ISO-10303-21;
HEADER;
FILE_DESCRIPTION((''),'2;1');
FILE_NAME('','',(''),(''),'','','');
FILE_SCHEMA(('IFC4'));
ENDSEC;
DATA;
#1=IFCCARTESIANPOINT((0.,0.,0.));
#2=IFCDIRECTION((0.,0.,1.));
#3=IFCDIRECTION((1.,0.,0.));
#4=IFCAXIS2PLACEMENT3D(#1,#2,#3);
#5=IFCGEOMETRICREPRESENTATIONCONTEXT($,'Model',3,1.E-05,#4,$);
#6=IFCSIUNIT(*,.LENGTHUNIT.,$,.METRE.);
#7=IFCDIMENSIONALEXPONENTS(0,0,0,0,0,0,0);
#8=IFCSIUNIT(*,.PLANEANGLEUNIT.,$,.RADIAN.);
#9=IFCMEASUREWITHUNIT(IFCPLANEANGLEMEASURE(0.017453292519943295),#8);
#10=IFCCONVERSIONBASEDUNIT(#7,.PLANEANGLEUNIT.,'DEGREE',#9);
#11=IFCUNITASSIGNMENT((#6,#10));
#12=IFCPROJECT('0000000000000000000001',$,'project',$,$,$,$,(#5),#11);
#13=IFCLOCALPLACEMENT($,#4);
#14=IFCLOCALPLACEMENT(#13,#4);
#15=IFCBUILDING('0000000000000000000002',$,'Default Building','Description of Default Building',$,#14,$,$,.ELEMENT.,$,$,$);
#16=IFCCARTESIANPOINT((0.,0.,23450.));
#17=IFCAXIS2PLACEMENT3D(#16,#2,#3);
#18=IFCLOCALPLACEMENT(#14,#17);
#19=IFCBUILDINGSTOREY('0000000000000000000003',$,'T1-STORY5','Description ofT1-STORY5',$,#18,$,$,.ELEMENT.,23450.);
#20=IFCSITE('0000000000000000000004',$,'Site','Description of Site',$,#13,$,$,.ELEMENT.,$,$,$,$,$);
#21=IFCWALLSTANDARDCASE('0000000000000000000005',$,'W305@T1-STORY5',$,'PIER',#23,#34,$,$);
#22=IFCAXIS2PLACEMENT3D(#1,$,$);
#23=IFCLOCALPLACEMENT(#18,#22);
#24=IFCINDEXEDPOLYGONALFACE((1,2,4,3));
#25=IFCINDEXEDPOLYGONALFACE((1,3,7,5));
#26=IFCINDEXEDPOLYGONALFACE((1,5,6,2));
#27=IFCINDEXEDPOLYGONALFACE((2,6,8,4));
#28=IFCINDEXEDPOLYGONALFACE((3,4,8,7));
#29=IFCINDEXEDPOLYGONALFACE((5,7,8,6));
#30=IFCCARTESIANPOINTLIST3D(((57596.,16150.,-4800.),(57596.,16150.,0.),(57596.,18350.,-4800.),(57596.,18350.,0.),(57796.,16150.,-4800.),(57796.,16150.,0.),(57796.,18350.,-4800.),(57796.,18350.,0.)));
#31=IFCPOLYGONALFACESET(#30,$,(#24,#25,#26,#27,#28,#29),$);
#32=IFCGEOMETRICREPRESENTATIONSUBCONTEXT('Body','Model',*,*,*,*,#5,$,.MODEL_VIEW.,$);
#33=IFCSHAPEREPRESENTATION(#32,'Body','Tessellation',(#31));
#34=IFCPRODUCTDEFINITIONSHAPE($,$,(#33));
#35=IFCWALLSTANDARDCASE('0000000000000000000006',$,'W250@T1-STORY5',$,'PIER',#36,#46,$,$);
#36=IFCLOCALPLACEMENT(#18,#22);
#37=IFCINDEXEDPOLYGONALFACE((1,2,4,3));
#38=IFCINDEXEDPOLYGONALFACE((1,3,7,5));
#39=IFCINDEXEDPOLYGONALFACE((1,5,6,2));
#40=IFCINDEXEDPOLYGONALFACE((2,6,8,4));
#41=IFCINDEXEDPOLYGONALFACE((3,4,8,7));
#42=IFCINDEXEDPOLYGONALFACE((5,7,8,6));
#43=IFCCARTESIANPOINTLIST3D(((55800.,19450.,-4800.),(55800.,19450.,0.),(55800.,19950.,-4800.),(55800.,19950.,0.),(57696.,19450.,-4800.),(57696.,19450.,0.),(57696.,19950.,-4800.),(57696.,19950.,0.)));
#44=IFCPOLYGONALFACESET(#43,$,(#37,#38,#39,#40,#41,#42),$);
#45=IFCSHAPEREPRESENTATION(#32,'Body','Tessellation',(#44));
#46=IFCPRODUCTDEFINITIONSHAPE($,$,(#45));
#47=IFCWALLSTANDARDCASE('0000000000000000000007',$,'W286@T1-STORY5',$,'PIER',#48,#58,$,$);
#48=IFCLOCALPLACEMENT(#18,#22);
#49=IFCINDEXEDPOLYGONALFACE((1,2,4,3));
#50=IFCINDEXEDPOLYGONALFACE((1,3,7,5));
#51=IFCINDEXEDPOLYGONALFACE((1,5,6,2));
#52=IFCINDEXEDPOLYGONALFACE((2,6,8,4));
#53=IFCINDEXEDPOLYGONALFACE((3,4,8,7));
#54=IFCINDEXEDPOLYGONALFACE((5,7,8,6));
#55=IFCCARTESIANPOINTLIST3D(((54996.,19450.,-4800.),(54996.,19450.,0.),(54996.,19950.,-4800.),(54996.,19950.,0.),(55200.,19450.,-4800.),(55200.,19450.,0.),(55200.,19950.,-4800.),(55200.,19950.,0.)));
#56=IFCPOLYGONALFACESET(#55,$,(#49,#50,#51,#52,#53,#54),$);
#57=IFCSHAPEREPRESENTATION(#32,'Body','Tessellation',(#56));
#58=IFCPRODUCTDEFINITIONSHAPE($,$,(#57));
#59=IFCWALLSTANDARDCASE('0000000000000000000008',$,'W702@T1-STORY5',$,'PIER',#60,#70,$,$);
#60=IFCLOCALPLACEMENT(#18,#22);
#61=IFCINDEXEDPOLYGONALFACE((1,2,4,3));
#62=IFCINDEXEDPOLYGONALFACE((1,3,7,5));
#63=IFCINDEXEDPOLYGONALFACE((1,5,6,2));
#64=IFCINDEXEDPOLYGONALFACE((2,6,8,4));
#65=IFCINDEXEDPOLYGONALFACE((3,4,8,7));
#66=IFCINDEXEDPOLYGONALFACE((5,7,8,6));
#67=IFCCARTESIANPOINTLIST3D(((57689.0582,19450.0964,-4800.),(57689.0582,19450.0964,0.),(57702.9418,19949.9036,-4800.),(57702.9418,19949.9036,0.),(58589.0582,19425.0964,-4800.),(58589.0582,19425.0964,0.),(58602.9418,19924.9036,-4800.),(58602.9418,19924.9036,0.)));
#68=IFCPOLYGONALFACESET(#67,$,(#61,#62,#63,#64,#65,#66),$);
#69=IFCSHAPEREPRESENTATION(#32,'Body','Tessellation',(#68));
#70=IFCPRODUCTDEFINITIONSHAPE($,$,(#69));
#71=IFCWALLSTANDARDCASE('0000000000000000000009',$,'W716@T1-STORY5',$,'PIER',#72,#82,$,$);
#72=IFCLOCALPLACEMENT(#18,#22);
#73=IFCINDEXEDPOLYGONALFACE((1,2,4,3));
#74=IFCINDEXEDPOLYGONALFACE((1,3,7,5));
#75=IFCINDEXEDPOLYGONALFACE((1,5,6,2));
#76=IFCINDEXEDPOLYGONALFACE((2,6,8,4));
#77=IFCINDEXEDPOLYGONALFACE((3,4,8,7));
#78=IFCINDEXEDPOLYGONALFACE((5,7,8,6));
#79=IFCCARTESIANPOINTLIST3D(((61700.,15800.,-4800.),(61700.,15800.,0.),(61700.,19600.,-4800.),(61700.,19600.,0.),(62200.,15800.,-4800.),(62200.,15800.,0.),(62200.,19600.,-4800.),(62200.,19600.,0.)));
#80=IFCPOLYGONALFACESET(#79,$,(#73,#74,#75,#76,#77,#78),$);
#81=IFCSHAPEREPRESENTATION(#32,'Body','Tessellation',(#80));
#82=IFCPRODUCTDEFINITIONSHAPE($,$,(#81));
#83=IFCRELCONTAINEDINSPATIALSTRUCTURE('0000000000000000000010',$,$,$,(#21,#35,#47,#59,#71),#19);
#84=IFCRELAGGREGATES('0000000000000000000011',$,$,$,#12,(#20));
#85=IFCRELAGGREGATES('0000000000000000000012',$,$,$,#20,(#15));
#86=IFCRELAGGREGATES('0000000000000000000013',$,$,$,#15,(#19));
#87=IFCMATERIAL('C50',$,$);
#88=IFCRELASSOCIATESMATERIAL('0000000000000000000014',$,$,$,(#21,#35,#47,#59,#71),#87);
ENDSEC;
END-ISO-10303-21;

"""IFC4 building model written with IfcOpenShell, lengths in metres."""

from ifc_helpers import new_model, entity, si_unit, converted_unit, frame, origin_with_axes, place, context, subcontext, project, spatial, indexed_curve, outline, extrude, material, element, save


model = new_model("IFC4")

# Units and contexts
model_context = context("Model", 3, precision=1e-05, world=origin_with_axes())
body_context = subcontext(model_context, "Body", "Model", "MODEL_VIEW")
ifc_project = project(units=[si_unit("LENGTHUNIT", "METRE"), converted_unit("PLANEANGLEUNIT", "DEGREE", entity("IfcPlaneAngleMeasure", 0.017453292519943295), si_unit("PLANEANGLEUNIT", "RADIAN"), dimensions=[0, 0, 0, 0, 0, 0, 0])], contexts=[model_context])

# Site, building, storey
site_placement = place(None, origin_with_axes())
site = spatial("IfcSite", under=ifc_project, at=site_placement, Name="Site", Description="Description of Site", CompositionType="ELEMENT")
building_placement = place(site_placement, origin_with_axes())
building = spatial("IfcBuilding", under=site, at=building_placement, Name="Default Building", Description="Description of Default Building", CompositionType="ELEMENT")
storey_placement = place(building_placement, frame((0.0, 0.0, 23450.0), z_axis=(0.0, 0.0, 1.0), x_axis=(1.0, 0.0, 0.0)))
storey = spatial("IfcBuildingStorey", under=building, at=storey_placement, Name="T1-STORY5", Description="Description ofT1-STORY5", CompositionType="ELEMENT", Elevation=23450.0)

# Shared definitions
ifc_material_1 = material(Name="C50")

# Walls
wall_1_placement = place(storey_placement, frame((57696.0, 16150.0, -4800.0), z_axis=(0.0, 0.0, 1.0), x_axis=(0.0, 1.0, 0.0)))
element("IfcWallStandardCase", 1, at=wall_1_placement, inside=storey, material=ifc_material_1, Name="W305@T1-STORY5", ObjectType="PIER", context=body_context, shape_type="SweptSolid", body=[
    extrude(outline(indexed_curve([(0.0, -100.0), (0.0, 100.0), (2200.0, 100.0), (2200.0, -100.0), (0.0, -100.0)], self_intersect=False)), origin_with_axes(), (0.0, 0.0, 1.0), 4800.0),
])
wall_2_placement = place(storey_placement, frame((55800.0, 19700.0, -4800.0), z_axis=(0.0, 0.0, 1.0), x_axis=(1.0, 0.0, 0.0)))
element("IfcWallStandardCase", 2, at=wall_2_placement, inside=storey, material=ifc_material_1, Name="W250@T1-STORY5", ObjectType="PIER", context=body_context, shape_type="SweptSolid", body=[
    extrude(outline(indexed_curve([(0.0, -250.0), (0.0, 250.0), (1896.0, 250.0), (1896.0, -250.0), (0.0, -250.0)], self_intersect=False)), origin_with_axes(), (0.0, 0.0, 1.0), 4800.0),
])
wall_3_placement = place(storey_placement, frame((54996.0, 19700.0, -4800.0), z_axis=(0.0, 0.0, 1.0), x_axis=(1.0, 0.0, 0.0)))
element("IfcWallStandardCase", 3, at=wall_3_placement, inside=storey, material=ifc_material_1, Name="W286@T1-STORY5", ObjectType="PIER", context=body_context, shape_type="SweptSolid", body=[
    extrude(outline(indexed_curve([(0.0, -250.0), (0.0, 250.0), (204.0, 250.0), (204.0, -250.0), (0.0, -250.0)], self_intersect=False)), origin_with_axes(), (0.0, 0.0, 1.0), 4800.0),
])
wall_4_placement = place(storey_placement, frame((57696.0, 19700.0, -4800.0), z_axis=(0.0, 0.0, 1.0), x_axis=(0.999614, -0.027767, 0.0)))
element("IfcWallStandardCase", 4, at=wall_4_placement, inside=storey, material=ifc_material_1, Name="W702@T1-STORY5", ObjectType="PIER", context=body_context, shape_type="SweptSolid", body=[
    extrude(outline(indexed_curve([(0.0, -250.0), (0.0, 250.0), (900.3472, 250.0), (900.3472, -250.0), (0.0, -250.0)], self_intersect=False)), origin_with_axes(), (0.0, 0.0, 1.0), 4800.0),
])
wall_5_placement = place(storey_placement, frame((61950.0, 15800.0, -4800.0), z_axis=(0.0, 0.0, 1.0), x_axis=(0.0, 1.0, 0.0)))
element("IfcWallStandardCase", 5, at=wall_5_placement, inside=storey, material=ifc_material_1, Name="W716@T1-STORY5", ObjectType="PIER", context=body_context, shape_type="SweptSolid", body=[
    extrude(outline(indexed_curve([(0.0, -250.0), (0.0, 250.0), (3800.0, 250.0), (3800.0, -250.0), (0.0, -250.0)], self_intersect=False)), origin_with_axes(), (0.0, 0.0, 1.0), 4800.0),
])

save(model, "model.ifc")
